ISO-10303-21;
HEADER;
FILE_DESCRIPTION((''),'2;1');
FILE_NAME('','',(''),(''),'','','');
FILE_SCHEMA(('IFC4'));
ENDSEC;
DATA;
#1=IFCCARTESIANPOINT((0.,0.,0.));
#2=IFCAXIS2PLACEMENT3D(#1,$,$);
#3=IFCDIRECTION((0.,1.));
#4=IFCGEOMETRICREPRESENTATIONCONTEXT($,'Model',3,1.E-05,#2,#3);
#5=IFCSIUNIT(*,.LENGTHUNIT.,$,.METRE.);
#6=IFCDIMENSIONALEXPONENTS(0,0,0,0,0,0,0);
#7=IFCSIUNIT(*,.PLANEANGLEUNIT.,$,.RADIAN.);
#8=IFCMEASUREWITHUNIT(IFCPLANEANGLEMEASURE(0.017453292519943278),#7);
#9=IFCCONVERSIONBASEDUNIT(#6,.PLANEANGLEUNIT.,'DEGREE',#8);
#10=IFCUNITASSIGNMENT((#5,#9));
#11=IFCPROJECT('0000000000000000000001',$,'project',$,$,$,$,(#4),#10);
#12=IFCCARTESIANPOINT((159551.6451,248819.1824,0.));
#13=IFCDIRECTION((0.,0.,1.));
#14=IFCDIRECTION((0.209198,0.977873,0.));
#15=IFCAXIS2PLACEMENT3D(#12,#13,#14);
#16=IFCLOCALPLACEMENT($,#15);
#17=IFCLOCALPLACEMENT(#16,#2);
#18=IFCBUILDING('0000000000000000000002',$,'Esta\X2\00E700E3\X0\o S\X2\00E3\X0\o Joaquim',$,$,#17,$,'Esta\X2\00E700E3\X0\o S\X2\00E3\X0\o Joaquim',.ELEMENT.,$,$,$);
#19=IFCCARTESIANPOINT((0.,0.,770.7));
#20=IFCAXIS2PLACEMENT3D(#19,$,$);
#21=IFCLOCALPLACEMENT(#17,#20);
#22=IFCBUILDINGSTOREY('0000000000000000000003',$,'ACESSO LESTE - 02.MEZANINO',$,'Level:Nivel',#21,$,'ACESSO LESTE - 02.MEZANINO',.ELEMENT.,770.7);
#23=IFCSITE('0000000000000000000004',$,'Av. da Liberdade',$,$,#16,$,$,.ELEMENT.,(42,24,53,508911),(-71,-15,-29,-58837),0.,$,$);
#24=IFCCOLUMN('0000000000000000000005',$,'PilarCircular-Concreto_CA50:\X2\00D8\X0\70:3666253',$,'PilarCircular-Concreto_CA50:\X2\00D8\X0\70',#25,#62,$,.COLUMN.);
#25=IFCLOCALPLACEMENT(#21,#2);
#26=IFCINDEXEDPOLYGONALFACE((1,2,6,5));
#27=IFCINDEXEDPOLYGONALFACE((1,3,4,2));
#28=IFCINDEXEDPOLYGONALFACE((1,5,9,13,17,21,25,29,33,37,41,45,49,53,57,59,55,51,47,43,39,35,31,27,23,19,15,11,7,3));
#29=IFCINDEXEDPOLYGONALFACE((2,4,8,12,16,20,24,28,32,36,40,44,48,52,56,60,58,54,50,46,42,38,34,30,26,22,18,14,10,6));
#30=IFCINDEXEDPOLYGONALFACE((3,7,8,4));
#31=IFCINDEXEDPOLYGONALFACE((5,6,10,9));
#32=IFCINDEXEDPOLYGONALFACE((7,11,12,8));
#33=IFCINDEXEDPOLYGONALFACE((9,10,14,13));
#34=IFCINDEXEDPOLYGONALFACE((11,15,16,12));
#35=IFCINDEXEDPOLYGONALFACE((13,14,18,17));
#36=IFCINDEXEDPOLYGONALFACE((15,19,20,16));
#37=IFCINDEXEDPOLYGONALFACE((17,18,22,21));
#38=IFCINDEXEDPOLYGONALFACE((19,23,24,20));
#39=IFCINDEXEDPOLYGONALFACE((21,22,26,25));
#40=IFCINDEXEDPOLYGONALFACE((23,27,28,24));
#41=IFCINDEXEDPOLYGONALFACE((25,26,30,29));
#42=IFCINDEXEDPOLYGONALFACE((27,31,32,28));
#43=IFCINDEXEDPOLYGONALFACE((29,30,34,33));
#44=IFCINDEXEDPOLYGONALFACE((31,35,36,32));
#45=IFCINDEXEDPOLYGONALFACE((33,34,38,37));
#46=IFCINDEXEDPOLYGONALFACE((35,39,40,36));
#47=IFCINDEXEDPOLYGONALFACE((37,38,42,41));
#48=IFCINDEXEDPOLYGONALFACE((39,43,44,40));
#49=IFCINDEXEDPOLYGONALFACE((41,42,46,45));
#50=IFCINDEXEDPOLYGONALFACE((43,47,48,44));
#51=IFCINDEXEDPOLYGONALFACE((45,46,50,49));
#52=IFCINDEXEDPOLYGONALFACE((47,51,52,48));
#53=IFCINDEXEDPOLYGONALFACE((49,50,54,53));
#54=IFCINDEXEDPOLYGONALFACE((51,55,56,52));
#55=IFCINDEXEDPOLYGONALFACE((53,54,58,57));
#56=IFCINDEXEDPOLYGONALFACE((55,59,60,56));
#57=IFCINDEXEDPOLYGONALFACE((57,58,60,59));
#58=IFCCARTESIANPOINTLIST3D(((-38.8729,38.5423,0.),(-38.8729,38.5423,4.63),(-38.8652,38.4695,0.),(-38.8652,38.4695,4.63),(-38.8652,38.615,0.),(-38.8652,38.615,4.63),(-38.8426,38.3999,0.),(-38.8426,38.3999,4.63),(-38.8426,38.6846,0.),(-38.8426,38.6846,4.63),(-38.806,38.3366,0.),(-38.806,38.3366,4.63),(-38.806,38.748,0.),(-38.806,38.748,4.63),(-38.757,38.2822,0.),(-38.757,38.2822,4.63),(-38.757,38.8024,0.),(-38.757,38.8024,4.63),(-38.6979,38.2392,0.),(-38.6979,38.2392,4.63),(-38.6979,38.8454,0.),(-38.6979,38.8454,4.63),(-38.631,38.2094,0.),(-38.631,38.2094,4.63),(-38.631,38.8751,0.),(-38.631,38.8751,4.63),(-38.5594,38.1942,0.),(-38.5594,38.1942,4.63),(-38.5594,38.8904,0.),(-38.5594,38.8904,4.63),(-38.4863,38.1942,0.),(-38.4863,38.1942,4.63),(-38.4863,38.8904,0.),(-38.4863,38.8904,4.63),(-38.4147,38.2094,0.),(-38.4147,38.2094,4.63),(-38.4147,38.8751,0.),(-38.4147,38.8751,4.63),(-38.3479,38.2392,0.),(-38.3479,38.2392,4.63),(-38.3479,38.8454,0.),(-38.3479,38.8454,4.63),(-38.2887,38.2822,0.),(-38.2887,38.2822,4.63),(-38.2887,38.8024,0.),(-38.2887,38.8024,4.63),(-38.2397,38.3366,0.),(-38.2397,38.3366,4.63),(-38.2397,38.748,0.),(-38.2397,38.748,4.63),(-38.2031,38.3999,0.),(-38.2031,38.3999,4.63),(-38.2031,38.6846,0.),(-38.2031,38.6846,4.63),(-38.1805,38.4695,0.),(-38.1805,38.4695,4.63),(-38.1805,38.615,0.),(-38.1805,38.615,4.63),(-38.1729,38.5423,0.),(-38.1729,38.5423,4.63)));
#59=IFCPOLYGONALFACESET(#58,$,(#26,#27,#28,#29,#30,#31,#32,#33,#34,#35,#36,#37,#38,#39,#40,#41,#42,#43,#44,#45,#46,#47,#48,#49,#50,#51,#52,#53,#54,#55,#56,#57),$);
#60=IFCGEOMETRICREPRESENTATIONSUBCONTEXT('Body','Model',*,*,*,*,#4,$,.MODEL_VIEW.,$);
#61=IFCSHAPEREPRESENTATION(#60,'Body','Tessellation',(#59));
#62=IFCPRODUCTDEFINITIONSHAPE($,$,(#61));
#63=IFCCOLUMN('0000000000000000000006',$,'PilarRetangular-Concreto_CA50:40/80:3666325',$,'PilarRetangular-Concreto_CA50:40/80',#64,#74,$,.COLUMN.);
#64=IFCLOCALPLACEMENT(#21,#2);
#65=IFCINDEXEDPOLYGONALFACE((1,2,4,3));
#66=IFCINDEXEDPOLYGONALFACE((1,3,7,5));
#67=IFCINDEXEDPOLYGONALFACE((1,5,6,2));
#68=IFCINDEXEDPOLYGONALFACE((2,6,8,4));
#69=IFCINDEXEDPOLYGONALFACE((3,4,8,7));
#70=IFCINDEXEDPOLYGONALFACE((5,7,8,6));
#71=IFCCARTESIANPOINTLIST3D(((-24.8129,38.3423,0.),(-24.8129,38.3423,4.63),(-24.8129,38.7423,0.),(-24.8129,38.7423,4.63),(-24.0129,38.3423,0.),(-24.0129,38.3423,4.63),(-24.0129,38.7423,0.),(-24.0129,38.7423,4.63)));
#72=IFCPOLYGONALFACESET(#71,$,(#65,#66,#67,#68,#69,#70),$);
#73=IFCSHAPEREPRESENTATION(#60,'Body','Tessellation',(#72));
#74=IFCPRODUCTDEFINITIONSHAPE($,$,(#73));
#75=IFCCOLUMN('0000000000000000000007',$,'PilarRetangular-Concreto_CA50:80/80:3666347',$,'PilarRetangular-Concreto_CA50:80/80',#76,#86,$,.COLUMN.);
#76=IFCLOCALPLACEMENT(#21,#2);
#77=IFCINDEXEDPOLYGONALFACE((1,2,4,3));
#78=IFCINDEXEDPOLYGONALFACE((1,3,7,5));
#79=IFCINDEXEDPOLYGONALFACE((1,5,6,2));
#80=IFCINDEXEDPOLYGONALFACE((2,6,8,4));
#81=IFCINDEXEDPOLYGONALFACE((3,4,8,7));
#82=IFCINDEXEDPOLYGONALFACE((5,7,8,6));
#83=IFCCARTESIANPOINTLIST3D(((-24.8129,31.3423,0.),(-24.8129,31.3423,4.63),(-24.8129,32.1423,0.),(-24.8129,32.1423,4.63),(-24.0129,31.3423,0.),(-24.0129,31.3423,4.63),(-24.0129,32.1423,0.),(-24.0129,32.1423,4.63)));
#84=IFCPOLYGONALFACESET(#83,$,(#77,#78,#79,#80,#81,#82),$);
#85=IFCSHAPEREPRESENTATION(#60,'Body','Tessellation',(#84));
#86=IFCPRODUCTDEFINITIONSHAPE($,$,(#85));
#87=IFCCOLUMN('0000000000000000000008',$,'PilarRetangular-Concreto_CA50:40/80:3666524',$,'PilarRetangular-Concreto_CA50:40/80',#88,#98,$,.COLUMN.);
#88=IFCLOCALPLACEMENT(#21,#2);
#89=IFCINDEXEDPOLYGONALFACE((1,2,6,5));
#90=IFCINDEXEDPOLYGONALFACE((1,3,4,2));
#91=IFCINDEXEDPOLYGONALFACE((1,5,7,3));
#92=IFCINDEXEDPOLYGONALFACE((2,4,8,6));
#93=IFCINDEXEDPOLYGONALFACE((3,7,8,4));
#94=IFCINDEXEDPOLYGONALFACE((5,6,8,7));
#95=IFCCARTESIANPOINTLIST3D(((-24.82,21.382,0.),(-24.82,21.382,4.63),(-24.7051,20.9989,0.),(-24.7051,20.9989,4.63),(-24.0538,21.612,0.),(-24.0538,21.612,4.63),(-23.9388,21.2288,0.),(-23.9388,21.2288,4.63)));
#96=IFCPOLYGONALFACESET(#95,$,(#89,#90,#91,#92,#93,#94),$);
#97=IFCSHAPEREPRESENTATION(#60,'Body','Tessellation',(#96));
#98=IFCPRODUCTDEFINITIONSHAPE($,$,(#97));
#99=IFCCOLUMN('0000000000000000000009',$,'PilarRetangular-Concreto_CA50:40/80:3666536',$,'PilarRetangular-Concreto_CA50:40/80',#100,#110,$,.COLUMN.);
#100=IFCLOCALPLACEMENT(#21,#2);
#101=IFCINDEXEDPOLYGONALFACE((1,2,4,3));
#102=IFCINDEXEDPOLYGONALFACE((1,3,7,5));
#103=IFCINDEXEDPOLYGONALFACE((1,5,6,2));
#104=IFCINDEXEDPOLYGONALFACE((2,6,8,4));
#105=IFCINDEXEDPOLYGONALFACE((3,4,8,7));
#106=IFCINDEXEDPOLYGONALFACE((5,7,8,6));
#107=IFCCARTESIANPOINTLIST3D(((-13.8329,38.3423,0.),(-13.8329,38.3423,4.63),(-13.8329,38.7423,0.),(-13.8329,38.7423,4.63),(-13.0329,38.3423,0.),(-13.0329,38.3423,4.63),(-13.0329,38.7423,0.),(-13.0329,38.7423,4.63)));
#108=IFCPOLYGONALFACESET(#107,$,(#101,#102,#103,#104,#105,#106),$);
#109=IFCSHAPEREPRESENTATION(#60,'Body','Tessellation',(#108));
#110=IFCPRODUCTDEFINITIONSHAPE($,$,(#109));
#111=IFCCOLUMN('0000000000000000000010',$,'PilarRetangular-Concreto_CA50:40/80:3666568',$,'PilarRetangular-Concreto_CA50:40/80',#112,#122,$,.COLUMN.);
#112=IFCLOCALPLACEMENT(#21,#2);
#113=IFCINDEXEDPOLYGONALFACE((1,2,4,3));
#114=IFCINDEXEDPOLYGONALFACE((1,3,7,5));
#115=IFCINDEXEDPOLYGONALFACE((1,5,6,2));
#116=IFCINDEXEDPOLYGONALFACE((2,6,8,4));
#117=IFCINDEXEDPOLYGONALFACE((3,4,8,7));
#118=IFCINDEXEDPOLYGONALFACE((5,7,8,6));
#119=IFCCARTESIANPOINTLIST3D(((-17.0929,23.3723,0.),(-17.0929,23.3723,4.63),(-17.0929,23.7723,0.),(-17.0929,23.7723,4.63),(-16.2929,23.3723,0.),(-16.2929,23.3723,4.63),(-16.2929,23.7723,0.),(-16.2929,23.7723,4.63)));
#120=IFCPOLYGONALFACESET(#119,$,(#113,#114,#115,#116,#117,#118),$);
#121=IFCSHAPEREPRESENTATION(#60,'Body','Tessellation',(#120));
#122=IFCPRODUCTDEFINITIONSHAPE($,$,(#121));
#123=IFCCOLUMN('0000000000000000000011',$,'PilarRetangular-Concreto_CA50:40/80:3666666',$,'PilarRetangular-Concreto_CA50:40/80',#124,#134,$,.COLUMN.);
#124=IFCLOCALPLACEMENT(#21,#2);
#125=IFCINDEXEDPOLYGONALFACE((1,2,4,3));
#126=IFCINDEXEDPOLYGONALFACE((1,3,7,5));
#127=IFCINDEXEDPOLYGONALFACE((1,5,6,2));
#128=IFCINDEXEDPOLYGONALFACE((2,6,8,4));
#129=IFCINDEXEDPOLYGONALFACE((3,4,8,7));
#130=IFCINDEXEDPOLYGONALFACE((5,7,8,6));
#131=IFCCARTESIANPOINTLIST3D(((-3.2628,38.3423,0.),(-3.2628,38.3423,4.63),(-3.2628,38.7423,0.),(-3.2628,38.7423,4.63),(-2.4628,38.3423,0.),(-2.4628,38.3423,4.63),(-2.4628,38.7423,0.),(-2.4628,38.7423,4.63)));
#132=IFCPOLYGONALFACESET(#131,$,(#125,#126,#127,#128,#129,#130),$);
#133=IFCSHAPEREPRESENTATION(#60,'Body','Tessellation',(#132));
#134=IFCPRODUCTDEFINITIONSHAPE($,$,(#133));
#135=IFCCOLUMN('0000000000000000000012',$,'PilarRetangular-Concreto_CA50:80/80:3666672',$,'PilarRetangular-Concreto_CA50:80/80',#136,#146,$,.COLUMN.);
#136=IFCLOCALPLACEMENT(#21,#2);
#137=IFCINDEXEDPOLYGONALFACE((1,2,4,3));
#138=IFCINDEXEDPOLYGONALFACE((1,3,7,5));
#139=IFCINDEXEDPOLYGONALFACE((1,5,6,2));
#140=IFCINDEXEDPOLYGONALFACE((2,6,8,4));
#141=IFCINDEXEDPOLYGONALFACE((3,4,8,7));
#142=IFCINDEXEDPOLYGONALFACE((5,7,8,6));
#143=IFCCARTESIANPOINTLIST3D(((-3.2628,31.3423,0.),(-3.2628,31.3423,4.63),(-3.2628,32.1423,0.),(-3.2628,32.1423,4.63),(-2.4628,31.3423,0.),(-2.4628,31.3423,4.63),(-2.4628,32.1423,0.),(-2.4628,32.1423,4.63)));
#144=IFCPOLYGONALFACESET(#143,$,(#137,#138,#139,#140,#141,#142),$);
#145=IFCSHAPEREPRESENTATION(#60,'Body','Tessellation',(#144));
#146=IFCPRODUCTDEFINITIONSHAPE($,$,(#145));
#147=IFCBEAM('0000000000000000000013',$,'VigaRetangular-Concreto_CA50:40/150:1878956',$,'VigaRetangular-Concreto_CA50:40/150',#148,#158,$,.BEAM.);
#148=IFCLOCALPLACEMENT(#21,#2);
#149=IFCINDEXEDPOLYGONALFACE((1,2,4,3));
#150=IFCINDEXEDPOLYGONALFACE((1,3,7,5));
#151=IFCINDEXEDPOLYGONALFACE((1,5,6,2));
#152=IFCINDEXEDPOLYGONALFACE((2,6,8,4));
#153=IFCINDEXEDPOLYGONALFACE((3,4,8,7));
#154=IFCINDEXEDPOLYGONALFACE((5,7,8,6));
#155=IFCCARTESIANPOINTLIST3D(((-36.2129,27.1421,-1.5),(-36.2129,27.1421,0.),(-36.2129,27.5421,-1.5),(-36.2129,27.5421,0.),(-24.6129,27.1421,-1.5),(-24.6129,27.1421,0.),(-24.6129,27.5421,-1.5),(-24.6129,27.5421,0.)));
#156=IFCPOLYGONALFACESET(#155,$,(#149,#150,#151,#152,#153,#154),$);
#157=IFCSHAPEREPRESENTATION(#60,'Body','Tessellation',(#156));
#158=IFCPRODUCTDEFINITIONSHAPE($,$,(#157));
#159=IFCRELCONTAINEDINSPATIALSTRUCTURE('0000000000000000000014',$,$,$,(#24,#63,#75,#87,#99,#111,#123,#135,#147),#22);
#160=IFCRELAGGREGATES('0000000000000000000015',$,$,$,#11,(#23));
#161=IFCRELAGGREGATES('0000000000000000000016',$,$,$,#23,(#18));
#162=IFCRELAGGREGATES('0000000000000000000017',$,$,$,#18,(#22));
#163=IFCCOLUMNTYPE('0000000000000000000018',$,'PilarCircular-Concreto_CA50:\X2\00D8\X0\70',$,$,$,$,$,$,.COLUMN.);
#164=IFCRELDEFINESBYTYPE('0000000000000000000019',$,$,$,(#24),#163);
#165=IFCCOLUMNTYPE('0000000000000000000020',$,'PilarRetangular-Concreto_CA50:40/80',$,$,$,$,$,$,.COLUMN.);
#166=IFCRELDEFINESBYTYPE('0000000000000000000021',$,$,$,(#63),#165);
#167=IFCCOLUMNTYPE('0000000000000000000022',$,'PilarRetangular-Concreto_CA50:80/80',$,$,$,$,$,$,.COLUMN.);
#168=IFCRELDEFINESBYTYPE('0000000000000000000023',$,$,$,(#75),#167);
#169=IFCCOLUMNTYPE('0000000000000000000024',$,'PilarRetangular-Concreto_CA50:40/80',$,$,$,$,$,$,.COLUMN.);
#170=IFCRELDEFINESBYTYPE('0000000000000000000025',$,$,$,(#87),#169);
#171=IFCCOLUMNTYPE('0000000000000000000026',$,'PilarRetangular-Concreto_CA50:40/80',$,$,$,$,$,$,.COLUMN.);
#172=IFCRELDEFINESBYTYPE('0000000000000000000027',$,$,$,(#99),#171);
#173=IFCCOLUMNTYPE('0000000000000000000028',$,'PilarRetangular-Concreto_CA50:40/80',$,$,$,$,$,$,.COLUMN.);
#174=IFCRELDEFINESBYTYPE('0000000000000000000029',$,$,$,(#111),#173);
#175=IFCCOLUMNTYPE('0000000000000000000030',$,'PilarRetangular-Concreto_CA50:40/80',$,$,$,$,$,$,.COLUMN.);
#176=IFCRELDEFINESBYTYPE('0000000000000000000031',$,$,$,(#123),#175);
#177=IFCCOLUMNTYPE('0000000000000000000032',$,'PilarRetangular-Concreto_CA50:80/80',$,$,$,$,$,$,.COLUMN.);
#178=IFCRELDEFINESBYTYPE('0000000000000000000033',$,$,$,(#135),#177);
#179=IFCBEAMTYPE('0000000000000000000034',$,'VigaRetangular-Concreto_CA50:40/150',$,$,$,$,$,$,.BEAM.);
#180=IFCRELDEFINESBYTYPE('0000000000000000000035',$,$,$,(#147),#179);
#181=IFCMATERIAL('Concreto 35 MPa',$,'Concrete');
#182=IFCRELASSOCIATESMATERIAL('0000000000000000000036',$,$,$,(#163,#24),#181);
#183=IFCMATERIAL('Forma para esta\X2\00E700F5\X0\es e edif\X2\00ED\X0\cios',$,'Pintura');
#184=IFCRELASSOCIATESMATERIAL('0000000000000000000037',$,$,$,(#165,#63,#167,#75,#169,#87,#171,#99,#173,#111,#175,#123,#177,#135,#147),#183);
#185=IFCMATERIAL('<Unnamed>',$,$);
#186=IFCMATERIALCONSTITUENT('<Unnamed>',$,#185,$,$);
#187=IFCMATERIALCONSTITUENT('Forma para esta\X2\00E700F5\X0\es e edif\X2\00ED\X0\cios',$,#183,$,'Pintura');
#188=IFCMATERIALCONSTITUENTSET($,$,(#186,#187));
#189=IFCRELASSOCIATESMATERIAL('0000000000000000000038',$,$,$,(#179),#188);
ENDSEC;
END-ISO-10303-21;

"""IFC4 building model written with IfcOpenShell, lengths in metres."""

from ifc_helpers import new_model, entity, si_unit, converted_unit, direction, frame, origin, place, context, subcontext, project, spatial, arc, indexed_curve, outline, extrude, source, transform, mapped, material, constituent, constituent_set, type_object, type_shapes, element, save


model = new_model("IFC4")

# Units and contexts
model_context = context("Model", 3, precision=1e-05, world=origin(), true_north=direction((0.0, 1.0)))
body_context = subcontext(model_context, "Body", "Model", "MODEL_VIEW")
ifc_project = project(units=[si_unit("LENGTHUNIT", "METRE"), converted_unit("PLANEANGLEUNIT", "DEGREE", entity("IfcPlaneAngleMeasure", 0.017453292519943278), si_unit("PLANEANGLEUNIT", "RADIAN"), dimensions=[0, 0, 0, 0, 0, 0, 0])], contexts=[model_context])

# Site, building, storey
site_placement = place(None, frame((159551.6451, 248819.1824, 0.0), z_axis=(0.0, 0.0, 1.0), x_axis=(0.209198, 0.977873, 0.0)))
site = spatial("IfcSite", under=ifc_project, at=site_placement, Name="Av. da Liberdade", CompositionType="ELEMENT", RefLatitude=(42, 24, 53, 508911), RefLongitude=(-71, -15, -29, -58837), RefElevation=0.0)
building_placement = place(site_placement, origin())
building = spatial("IfcBuilding", under=site, at=building_placement, Name="Estação São Joaquim", LongName="Estação São Joaquim", CompositionType="ELEMENT")
storey_placement = place(building_placement, frame((0.0, 0.0, 770.7)))
storey = spatial("IfcBuildingStorey", under=building, at=storey_placement, Name="ACESSO LESTE - 02.MEZANINO", ObjectType="Level:Nivel", LongName="ACESSO LESTE - 02.MEZANINO", CompositionType="ELEMENT", Elevation=770.7)

# Columns
ifc_material_1 = material(Name="Concreto 35 MPa", Category="Concrete")
column_type_1 = type_object("IfcColumnType", Name="PilarCircular-Concreto_CA50:Ø70", PredefinedType="COLUMN", material=ifc_material_1)
shared_shape_1 = source(origin(), body_context, "Body", "SweptSolid", [
    extrude(outline(indexed_curve([(-0.35, 0.0), (0.0, -0.35), (0.35, 0.0), (0.0, 0.35)], segments=[arc(1, 2, 3), arc(3, 4, 1)], self_intersect=False)), frame((-38.5229, 38.5423, 770.7)), (0.0, 0.0, 1.0), 4.63),
])
type_shapes(column_type_1, [shared_shape_1])
column_1_placement = place(storey_placement, frame((0.0, 0.0, -770.7)))
element("IfcColumn", 1, at=column_1_placement, inside=storey, type_object=column_type_1, material=ifc_material_1, Name="PilarCircular-Concreto_CA50:Ø70:3666253", ObjectType="PilarCircular-Concreto_CA50:Ø70", PredefinedType="COLUMN", context=body_context, shape_type="MappedRepresentation", body=[
    mapped(shared_shape_1, transform((0.0, 0.0, 0.0), scale=1.0)),
])
ifc_material_2 = material(Name="Forma para estações e edifícios", Category="Pintura")
column_type_2 = type_object("IfcColumnType", Name="PilarRetangular-Concreto_CA50:40/80", PredefinedType="COLUMN", material=ifc_material_2)
shared_shape_2 = source(origin(), body_context, "Body", "SweptSolid", [
    extrude(outline(indexed_curve([(-0.2, -0.4), (0.2, -0.4), (0.2, 0.4), (-0.2, 0.4), (-0.2, -0.4)], self_intersect=False)), frame((-24.4129, 38.5423, 770.7), z_axis=(0.0, 0.0, 1.0), x_axis=(0.0, -1.0, 0.0)), (0.0, 0.0, 1.0), 4.63),
])
type_shapes(column_type_2, [shared_shape_2])
column_2_placement = place(storey_placement, frame((0.0, 0.0, -770.7)))
element("IfcColumn", 2, at=column_2_placement, inside=storey, type_object=column_type_2, material=ifc_material_2, Name="PilarRetangular-Concreto_CA50:40/80:3666325", ObjectType="PilarRetangular-Concreto_CA50:40/80", PredefinedType="COLUMN", context=body_context, shape_type="MappedRepresentation", body=[
    mapped(shared_shape_2, transform((0.0, 0.0, 0.0), scale=1.0)),
])
column_type_3 = type_object("IfcColumnType", Name="PilarRetangular-Concreto_CA50:80/80", PredefinedType="COLUMN", material=ifc_material_2)
shared_shape_3 = source(origin(), body_context, "Body", "SweptSolid", [
    extrude(outline(indexed_curve([(-0.4, -0.4), (0.4, -0.4), (0.4, 0.4), (-0.4, 0.4), (-0.4, -0.4)], self_intersect=False)), frame((-24.4129, 31.7423, 770.7), z_axis=(0.0, 0.0, 1.0), x_axis=(-1.0, 0.0, 0.0)), (0.0, 0.0, 1.0), 4.63),
])
type_shapes(column_type_3, [shared_shape_3])
column_3_placement = place(storey_placement, frame((0.0, 0.0, -770.7)))
element("IfcColumn", 3, at=column_3_placement, inside=storey, type_object=column_type_3, material=ifc_material_2, Name="PilarRetangular-Concreto_CA50:80/80:3666347", ObjectType="PilarRetangular-Concreto_CA50:80/80", PredefinedType="COLUMN", context=body_context, shape_type="MappedRepresentation", body=[
    mapped(shared_shape_3, transform((0.0, 0.0, 0.0), scale=1.0)),
])
column_type_4 = type_object("IfcColumnType", Name="PilarRetangular-Concreto_CA50:40/80", PredefinedType="COLUMN", material=ifc_material_2)
shared_shape_4 = source(origin(), body_context, "Body", "SweptSolid", [
    extrude(outline(indexed_curve([(-0.2, -0.4), (0.2, -0.4), (0.2, 0.4), (-0.2, 0.4), (-0.2, -0.4)], self_intersect=False)), frame((-24.3794, 21.3054, 770.7), z_axis=(0.0, 0.0, 1.0), x_axis=(0.287438, -0.957799, 0.0)), (0.0, 0.0, 1.0), 4.63),
])
type_shapes(column_type_4, [shared_shape_4])
column_4_placement = place(storey_placement, frame((0.0, 0.0, -770.7)))
element("IfcColumn", 4, at=column_4_placement, inside=storey, type_object=column_type_4, material=ifc_material_2, Name="PilarRetangular-Concreto_CA50:40/80:3666524", ObjectType="PilarRetangular-Concreto_CA50:40/80", PredefinedType="COLUMN", context=body_context, shape_type="MappedRepresentation", body=[
    mapped(shared_shape_4, transform((0.0, 0.0, 0.0), scale=1.0)),
])
column_type_5 = type_object("IfcColumnType", Name="PilarRetangular-Concreto_CA50:40/80", PredefinedType="COLUMN", material=ifc_material_2)
shared_shape_5 = source(origin(), body_context, "Body", "SweptSolid", [
    extrude(outline(indexed_curve([(-0.2, -0.4), (0.2, -0.4), (0.2, 0.4), (-0.2, 0.4), (-0.2, -0.4)], self_intersect=False)), frame((-13.4329, 38.5423, 770.7), z_axis=(0.0, 0.0, 1.0), x_axis=(0.0, 1.0, 0.0)), (0.0, 0.0, 1.0), 4.63),
])
type_shapes(column_type_5, [shared_shape_5])
column_5_placement = place(storey_placement, frame((0.0, 0.0, -770.7)))
element("IfcColumn", 5, at=column_5_placement, inside=storey, type_object=column_type_5, material=ifc_material_2, Name="PilarRetangular-Concreto_CA50:40/80:3666536", ObjectType="PilarRetangular-Concreto_CA50:40/80", PredefinedType="COLUMN", context=body_context, shape_type="MappedRepresentation", body=[
    mapped(shared_shape_5, transform((0.0, 0.0, 0.0), scale=1.0)),
])
column_type_6 = type_object("IfcColumnType", Name="PilarRetangular-Concreto_CA50:40/80", PredefinedType="COLUMN", material=ifc_material_2)
shared_shape_6 = source(origin(), body_context, "Body", "SweptSolid", [
    extrude(outline(indexed_curve([(-0.2, -0.4), (0.2, -0.4), (0.2, 0.4), (-0.2, 0.4), (-0.2, -0.4)], self_intersect=False)), frame((-16.6929, 23.5723, 770.7), z_axis=(0.0, 0.0, 1.0), x_axis=(0.0, -1.0, 0.0)), (0.0, 0.0, 1.0), 4.63),
])
type_shapes(column_type_6, [shared_shape_6])
column_6_placement = place(storey_placement, frame((0.0, 0.0, -770.7)))
element("IfcColumn", 6, at=column_6_placement, inside=storey, type_object=column_type_6, material=ifc_material_2, Name="PilarRetangular-Concreto_CA50:40/80:3666568", ObjectType="PilarRetangular-Concreto_CA50:40/80", PredefinedType="COLUMN", context=body_context, shape_type="MappedRepresentation", body=[
    mapped(shared_shape_6, transform((0.0, 0.0, 0.0), scale=1.0)),
])
column_type_7 = type_object("IfcColumnType", Name="PilarRetangular-Concreto_CA50:40/80", PredefinedType="COLUMN", material=ifc_material_2)
shared_shape_7 = source(origin(), body_context, "Body", "SweptSolid", [
    extrude(outline(indexed_curve([(-0.2, -0.4), (0.2, -0.4), (0.2, 0.4), (-0.2, 0.4), (-0.2, -0.4)], self_intersect=False)), frame((-2.8628, 38.5423, 770.7), z_axis=(0.0, 0.0, 1.0), x_axis=(0.0, 1.0, 0.0)), (0.0, 0.0, 1.0), 4.63),
])
type_shapes(column_type_7, [shared_shape_7])
column_7_placement = place(storey_placement, frame((0.0, 0.0, -770.7)))
element("IfcColumn", 7, at=column_7_placement, inside=storey, type_object=column_type_7, material=ifc_material_2, Name="PilarRetangular-Concreto_CA50:40/80:3666666", ObjectType="PilarRetangular-Concreto_CA50:40/80", PredefinedType="COLUMN", context=body_context, shape_type="MappedRepresentation", body=[
    mapped(shared_shape_7, transform((0.0, 0.0, 0.0), scale=1.0)),
])
column_type_8 = type_object("IfcColumnType", Name="PilarRetangular-Concreto_CA50:80/80", PredefinedType="COLUMN", material=ifc_material_2)
shared_shape_8 = source(origin(), body_context, "Body", "SweptSolid", [
    extrude(outline(indexed_curve([(-0.4, -0.4), (0.4, -0.4), (0.4, 0.4), (-0.4, 0.4), (-0.4, -0.4)], self_intersect=False)), frame((-2.8628, 31.7423, 770.7), z_axis=(0.0, 0.0, 1.0), x_axis=(-1.0, 0.0, 0.0)), (0.0, 0.0, 1.0), 4.63),
])
type_shapes(column_type_8, [shared_shape_8])
column_8_placement = place(storey_placement, frame((0.0, 0.0, -770.7)))
element("IfcColumn", 8, at=column_8_placement, inside=storey, type_object=column_type_8, material=ifc_material_2, Name="PilarRetangular-Concreto_CA50:80/80:3666672", ObjectType="PilarRetangular-Concreto_CA50:80/80", PredefinedType="COLUMN", context=body_context, shape_type="MappedRepresentation", body=[
    mapped(shared_shape_8, transform((0.0, 0.0, 0.0), scale=1.0)),
])

# Beam
ifc_material_3 = material(Name="<Unnamed>")
ifc_constituent_1 = constituent(ifc_material_3, Name="<Unnamed>")
ifc_constituent_2 = constituent(ifc_material_2, Name="Forma para estações e edifícios", Category="Pintura")
ifc_constituent_set_1 = constituent_set(constituents=[ifc_constituent_1, ifc_constituent_2])
beam_type_1 = type_object("IfcBeamType", Name="VigaRetangular-Concreto_CA50:40/150", PredefinedType="BEAM", material=ifc_constituent_set_1)
shared_shape_9 = source(origin(), body_context, "Body", "SweptSolid", [
    extrude(outline(indexed_curve([(-0.75, -0.2), (0.75, -0.2), (0.75, 0.2), (-0.75, 0.2), (-0.75, -0.2)], self_intersect=False)), frame((-36.2129, 27.3421, 769.95), z_axis=(1.0, 0.0, 0.0), x_axis=(0.0, 0.0, -1.0)), (0.0, 0.0, 1.0), 11.6),
])
type_shapes(beam_type_1, [shared_shape_9])
beam_1_placement = place(storey_placement, frame((0.0, 0.0, -770.7)))
element("IfcBeam", 9, at=beam_1_placement, inside=storey, type_object=beam_type_1, material=ifc_material_2, Name="VigaRetangular-Concreto_CA50:40/150:1878956", ObjectType="VigaRetangular-Concreto_CA50:40/150", PredefinedType="BEAM", context=body_context, shape_type="MappedRepresentation", body=[
    mapped(shared_shape_9, transform((0.0, 0.0, 0.0), scale=1.0)),
])

save(model, "model.ifc")
